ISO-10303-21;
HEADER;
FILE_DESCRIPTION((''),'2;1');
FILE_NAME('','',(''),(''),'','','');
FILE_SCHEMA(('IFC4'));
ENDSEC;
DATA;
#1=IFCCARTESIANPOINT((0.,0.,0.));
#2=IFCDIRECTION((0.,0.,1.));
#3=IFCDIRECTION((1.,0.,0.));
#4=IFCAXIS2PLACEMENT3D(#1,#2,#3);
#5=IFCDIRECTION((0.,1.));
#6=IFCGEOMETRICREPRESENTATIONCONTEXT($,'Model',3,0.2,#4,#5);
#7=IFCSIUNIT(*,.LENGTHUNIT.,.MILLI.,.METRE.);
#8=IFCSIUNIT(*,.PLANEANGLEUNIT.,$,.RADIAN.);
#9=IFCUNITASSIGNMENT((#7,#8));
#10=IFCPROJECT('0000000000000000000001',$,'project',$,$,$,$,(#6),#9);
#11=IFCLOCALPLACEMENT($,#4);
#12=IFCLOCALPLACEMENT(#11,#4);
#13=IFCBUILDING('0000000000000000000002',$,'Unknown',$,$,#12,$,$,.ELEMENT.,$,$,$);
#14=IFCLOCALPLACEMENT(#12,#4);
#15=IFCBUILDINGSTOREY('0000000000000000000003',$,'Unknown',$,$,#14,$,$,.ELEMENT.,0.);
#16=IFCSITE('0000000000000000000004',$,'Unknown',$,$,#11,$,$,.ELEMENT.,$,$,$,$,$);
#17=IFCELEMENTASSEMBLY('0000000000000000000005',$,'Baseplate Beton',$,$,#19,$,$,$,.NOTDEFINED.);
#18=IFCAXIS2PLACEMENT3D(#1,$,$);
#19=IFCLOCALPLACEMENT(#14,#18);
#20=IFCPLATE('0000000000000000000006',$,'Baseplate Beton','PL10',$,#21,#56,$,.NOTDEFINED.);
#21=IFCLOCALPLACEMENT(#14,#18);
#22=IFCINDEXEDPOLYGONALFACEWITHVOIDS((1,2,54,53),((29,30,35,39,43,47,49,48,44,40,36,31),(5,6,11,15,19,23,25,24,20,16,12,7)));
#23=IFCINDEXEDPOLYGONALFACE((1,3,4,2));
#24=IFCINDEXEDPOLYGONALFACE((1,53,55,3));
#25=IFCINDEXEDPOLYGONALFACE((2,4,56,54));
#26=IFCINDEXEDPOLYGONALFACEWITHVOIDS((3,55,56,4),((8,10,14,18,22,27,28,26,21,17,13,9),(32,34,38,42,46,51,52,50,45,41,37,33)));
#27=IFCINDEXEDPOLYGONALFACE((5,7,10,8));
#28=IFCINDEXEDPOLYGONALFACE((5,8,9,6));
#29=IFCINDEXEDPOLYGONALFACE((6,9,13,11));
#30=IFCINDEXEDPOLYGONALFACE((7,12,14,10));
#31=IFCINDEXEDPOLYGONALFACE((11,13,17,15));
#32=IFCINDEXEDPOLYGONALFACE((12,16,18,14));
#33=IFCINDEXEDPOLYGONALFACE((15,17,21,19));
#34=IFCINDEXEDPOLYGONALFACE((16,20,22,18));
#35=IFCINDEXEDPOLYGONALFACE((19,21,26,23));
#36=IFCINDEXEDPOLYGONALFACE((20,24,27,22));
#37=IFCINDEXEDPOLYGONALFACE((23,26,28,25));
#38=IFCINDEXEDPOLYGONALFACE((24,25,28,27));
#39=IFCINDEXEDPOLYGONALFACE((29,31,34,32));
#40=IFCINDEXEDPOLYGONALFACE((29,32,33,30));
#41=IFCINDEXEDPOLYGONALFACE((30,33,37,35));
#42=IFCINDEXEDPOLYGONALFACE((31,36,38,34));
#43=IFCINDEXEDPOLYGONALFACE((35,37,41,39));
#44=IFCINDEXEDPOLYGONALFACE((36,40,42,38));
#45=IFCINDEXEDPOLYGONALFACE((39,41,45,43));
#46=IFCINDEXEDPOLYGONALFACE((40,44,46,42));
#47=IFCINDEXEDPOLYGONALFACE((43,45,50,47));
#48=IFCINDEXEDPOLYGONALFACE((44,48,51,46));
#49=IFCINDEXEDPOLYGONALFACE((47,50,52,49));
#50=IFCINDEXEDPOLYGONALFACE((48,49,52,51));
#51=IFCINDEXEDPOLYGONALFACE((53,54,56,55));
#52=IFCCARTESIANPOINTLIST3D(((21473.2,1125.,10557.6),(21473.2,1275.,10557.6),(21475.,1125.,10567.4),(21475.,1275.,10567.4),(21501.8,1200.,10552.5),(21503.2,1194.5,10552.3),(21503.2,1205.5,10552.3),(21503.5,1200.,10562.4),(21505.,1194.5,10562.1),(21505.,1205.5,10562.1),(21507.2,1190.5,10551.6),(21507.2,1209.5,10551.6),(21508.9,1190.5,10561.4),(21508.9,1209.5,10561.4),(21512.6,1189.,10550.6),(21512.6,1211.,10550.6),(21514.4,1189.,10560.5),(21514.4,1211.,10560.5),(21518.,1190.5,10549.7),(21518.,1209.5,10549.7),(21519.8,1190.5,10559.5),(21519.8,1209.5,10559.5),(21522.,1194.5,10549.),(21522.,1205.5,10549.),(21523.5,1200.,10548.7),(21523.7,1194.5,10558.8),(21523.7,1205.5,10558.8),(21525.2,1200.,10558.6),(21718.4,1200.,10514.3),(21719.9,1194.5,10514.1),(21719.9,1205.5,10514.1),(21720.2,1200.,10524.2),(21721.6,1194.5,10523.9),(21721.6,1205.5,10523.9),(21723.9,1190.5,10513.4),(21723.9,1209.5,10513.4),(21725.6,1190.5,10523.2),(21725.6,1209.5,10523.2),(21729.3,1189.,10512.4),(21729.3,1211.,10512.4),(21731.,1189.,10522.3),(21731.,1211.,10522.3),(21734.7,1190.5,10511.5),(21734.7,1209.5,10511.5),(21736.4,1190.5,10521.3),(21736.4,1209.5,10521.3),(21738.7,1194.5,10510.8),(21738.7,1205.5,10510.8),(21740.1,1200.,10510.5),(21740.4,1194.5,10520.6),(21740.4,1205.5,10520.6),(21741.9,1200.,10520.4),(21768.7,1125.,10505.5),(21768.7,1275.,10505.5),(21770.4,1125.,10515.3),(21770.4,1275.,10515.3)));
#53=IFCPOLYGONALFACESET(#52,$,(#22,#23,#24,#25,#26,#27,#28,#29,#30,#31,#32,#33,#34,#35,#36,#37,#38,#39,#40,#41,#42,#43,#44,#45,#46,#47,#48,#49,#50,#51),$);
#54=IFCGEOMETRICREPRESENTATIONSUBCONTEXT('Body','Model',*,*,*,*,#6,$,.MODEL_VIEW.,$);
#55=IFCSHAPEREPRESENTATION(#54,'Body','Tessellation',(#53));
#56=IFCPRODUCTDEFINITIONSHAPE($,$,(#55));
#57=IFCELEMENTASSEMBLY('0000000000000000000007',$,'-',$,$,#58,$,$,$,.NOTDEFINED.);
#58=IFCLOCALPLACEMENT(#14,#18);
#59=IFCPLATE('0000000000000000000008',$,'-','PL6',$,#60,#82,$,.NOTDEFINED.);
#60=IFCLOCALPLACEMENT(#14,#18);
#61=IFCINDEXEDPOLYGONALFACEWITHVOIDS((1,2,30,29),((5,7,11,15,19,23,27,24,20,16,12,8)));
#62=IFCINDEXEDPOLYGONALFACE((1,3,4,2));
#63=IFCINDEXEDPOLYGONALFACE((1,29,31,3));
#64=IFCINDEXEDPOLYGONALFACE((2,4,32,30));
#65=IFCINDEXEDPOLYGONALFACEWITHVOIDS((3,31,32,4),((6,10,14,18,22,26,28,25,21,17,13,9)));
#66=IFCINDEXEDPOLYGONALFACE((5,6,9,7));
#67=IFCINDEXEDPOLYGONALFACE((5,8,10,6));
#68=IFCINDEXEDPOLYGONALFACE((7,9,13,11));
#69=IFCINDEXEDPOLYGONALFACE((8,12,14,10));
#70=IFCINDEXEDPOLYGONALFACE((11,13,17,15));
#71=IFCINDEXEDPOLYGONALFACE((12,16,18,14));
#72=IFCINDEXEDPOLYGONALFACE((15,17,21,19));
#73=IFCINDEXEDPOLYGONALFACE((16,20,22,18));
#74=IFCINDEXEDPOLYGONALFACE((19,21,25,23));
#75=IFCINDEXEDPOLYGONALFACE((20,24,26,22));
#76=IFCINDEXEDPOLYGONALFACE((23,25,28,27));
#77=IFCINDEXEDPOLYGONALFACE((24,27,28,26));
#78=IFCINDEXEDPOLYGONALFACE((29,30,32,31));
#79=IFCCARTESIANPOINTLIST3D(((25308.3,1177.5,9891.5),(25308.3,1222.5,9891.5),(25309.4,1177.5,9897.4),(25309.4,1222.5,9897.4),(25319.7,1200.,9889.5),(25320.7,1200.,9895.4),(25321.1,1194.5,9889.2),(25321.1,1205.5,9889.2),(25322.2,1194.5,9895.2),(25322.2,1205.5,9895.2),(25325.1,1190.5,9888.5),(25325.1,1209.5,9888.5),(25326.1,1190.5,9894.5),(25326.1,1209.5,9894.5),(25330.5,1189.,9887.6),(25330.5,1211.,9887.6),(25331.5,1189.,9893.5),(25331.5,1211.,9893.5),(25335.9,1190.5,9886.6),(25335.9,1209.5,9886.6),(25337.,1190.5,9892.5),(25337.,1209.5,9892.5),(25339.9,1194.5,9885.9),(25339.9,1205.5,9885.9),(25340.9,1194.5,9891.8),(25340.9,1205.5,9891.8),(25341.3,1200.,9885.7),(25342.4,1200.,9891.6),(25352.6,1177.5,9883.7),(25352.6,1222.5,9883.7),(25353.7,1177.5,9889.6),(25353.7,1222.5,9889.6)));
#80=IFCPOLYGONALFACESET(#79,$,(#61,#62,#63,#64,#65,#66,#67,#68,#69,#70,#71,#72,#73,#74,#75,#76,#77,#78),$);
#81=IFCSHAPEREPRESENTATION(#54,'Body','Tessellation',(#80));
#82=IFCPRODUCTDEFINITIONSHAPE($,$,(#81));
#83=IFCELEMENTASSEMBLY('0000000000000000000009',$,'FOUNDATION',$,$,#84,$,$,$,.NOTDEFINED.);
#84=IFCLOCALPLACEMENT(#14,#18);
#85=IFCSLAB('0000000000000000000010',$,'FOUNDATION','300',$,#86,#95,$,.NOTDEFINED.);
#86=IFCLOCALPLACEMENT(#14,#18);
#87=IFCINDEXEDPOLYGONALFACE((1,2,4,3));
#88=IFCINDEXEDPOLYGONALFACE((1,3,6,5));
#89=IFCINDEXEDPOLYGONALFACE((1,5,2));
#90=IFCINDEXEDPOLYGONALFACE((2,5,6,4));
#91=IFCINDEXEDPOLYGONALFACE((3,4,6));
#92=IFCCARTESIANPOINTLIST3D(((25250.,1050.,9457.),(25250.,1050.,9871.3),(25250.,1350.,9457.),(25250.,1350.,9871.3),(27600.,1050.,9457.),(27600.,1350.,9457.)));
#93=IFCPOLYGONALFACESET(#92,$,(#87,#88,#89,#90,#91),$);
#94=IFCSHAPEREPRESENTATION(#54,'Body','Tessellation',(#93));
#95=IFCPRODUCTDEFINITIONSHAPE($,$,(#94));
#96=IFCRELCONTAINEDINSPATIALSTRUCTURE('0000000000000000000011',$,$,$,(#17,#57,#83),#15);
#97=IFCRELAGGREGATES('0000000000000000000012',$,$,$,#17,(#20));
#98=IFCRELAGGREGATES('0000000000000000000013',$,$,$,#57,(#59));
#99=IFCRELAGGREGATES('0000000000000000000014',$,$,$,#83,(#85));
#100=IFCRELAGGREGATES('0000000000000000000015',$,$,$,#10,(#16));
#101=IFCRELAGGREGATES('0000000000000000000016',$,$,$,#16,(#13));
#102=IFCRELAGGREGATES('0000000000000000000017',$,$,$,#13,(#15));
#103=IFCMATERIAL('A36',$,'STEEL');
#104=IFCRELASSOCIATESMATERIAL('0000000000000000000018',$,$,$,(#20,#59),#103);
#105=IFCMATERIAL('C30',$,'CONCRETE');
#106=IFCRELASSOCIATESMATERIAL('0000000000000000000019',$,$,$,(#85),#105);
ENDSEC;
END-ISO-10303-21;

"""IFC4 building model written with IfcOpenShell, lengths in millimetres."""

from ifc_helpers import new_model, si_unit, direction, frame, origin_with_axes, place, context, subcontext, project, spatial, line, indexed_curve, outline, extrude, material, element, aggregate, save


model = new_model("IFC4")

# Units and contexts
model_context = context("Model", 3, precision=0.2, world=origin_with_axes(), true_north=direction((0.0, 1.0)))
body_context = subcontext(model_context, "Body", "Model", "MODEL_VIEW")
ifc_project = project(units=[si_unit("LENGTHUNIT", "METRE", prefix="MILLI"), si_unit("PLANEANGLEUNIT", "RADIAN")], contexts=[model_context])

# Site, building, storey
site_placement = place(None, origin_with_axes())
site = spatial("IfcSite", under=ifc_project, at=site_placement, Name="Unknown", CompositionType="ELEMENT")
building_placement = place(site_placement, origin_with_axes())
building = spatial("IfcBuilding", under=site, at=building_placement, Name="Unknown", CompositionType="ELEMENT")
storey_placement = place(building_placement, origin_with_axes())
storey = spatial("IfcBuildingStorey", under=building, at=storey_placement, Name="Unknown", CompositionType="ELEMENT", Elevation=0.0)

# Shared definitions
ifc_material_1 = material(Name="A36", Category="STEEL")

# Element assembly, plate, voiding features
assembly_1_placement = place(storey_placement, frame((21769.5, 1125.0, 10510.4), z_axis=(0.173648, 0.0, 0.984808), x_axis=(0.0, 1.0, 0.0)))
assembly_1 = element("IfcElementAssembly", 1, at=assembly_1_placement, inside=storey, Name="Baseplate Beton", PredefinedType="NOTDEFINED")
plate_1_placement = place(assembly_1_placement, origin_with_axes())
plate_1 = element("IfcPlate", 2, at=plate_1_placement, material=ifc_material_1, Name="Baseplate Beton", Description="PL10", PredefinedType="NOTDEFINED", context=body_context, shape_type="SolidModel", body=[
    extrude(outline(indexed_curve([(0.0, 0.0), (150.0, 0.0), (150.0, 300.0), (0.0, 300.0)], segments=[line(1, 2, 3, 4, 1)])), frame((0.0, 0.0, 5.0), z_axis=(0.0, 0.0, 1.0), x_axis=(1.0, 0.0, 0.0)), (0.0, 0.0, -1.0), 10.0),
])
voiding_feature_1_placement = place(plate_1_placement, frame((75.0, 260.0, 5.5), z_axis=(1.0, 0.0, 0.0), x_axis=(0.0, 0.0, -1.0)))
element("IfcVoidingFeature", 3, at=voiding_feature_1_placement, cuts=plate_1, Name="BEAM", PredefinedType="HOLE", context=body_context, shape_type="SolidModel", body=[
    extrude(outline(indexed_curve([(11.0, 0.0), (9.5, 5.5), (5.5, 9.5), (0.0, 11.0), (-5.5, 9.5), (-9.5, 5.5), (-11.0, 0.0), (-9.5, -5.5), (-5.5, -9.5), (0.0, -11.0), (5.5, -9.5), (9.5, -5.5)], segments=[line(1, 2, 3, 4, 5, 6, 7, 8, 9, 10, 11, 12, 1)])), frame((0.0, 0.0, 0.0), z_axis=(-1.0, 0.0, 0.0), x_axis=(0.0, 0.0, 1.0)), (0.0, 0.0, -1.0), 11.0),
])
voiding_feature_2_placement = place(plate_1_placement, frame((75.0, 40.0, 5.5), z_axis=(1.0, 0.0, 0.0), x_axis=(0.0, 0.0, -1.0)))
element("IfcVoidingFeature", 4, at=voiding_feature_2_placement, cuts=plate_1, Name="BEAM", PredefinedType="HOLE", context=body_context, shape_type="SolidModel", body=[
    extrude(outline(indexed_curve([(11.0, 0.0), (9.5, 5.5), (5.5, 9.5), (0.0, 11.0), (-5.5, 9.5), (-9.5, 5.5), (-11.0, 0.0), (-9.5, -5.5), (-5.5, -9.5), (0.0, -11.0), (5.5, -9.5), (9.5, -5.5)], segments=[line(1, 2, 3, 4, 5, 6, 7, 8, 9, 10, 11, 12, 1)])), frame((0.0, 0.0, 0.0), z_axis=(-1.0, 0.0, 0.0), x_axis=(0.0, 0.0, 1.0)), (0.0, 0.0, -1.0), 11.0),
])
aggregate(assembly_1, [plate_1])

# Element assembly, plate, voiding feature
assembly_2_placement = place(storey_placement, frame((25353.2, 1177.5, 9886.6), z_axis=(0.173648, 0.0, 0.984808), x_axis=(0.0, 1.0, 0.0)))
assembly_2 = element("IfcElementAssembly", 5, at=assembly_2_placement, inside=storey, Name="-", PredefinedType="NOTDEFINED")
plate_2_placement = place(assembly_2_placement, origin_with_axes())
plate_2 = element("IfcPlate", 6, at=plate_2_placement, material=ifc_material_1, Name="-", Description="PL6", PredefinedType="NOTDEFINED", context=body_context, shape_type="SolidModel", body=[
    extrude(outline(indexed_curve([(0.0, 0.0), (45.0, 0.0), (45.0, 45.0), (0.0, 45.0)], segments=[line(1, 2, 3, 4, 1)])), frame((0.0, 0.0, 3.0), z_axis=(0.0, 0.0, 1.0), x_axis=(1.0, 0.0, 0.0)), (0.0, 0.0, -1.0), 6.0),
])
voiding_feature_3_placement = place(plate_2_placement, frame((22.5, 22.5, 3.5), z_axis=(1.0, 0.0, 0.0), x_axis=(0.0, 0.0, -1.0)))
element("IfcVoidingFeature", 7, at=voiding_feature_3_placement, cuts=plate_2, Name="BEAM", PredefinedType="HOLE", context=body_context, shape_type="SolidModel", body=[
    extrude(outline(indexed_curve([(11.0, 0.0), (9.5, 5.5), (5.5, 9.5), (0.0, 11.0), (-5.5, 9.5), (-9.5, 5.5), (-11.0, 0.0), (-9.5, -5.5), (-5.5, -9.5), (0.0, -11.0), (5.5, -9.5), (9.5, -5.5)], segments=[line(1, 2, 3, 4, 5, 6, 7, 8, 9, 10, 11, 12, 1)])), frame((0.0, 0.0, 0.0), z_axis=(-1.0, 0.0, 0.0), x_axis=(0.0, 0.0, 1.0)), (0.0, 0.0, -1.0), 7.0),
])
aggregate(assembly_2, [plate_2])

# Element assembly, slab
assembly_3_placement = place(storey_placement, frame((25250.0, 1200.0, 9871.3), z_axis=(0.0, -1.0, 0.0), x_axis=(0.0, 0.0, -1.0)))
assembly_3 = element("IfcElementAssembly", 8, at=assembly_3_placement, inside=storey, Name="FOUNDATION", PredefinedType="NOTDEFINED")
ifc_material_2 = material(Name="C30", Category="CONCRETE")
slab_placement = place(assembly_3_placement, origin_with_axes())
slab = element("IfcSlab", 9, at=slab_placement, material=ifc_material_2, Name="FOUNDATION", Description="300", PredefinedType="NOTDEFINED", context=body_context, shape_type="SolidModel", body=[
    extrude(outline(indexed_curve([(0.0, 0.0), (414.4, 0.0), (414.4, 2350.0)], segments=[line(1, 2, 3, 1)])), frame((0.0, 0.0, 150.0), z_axis=(0.0, 0.0, 1.0), x_axis=(1.0, 0.0, 0.0)), (0.0, 0.0, -1.0), 300.0),
])
aggregate(assembly_3, [slab])

save(model, "model.ifc")
